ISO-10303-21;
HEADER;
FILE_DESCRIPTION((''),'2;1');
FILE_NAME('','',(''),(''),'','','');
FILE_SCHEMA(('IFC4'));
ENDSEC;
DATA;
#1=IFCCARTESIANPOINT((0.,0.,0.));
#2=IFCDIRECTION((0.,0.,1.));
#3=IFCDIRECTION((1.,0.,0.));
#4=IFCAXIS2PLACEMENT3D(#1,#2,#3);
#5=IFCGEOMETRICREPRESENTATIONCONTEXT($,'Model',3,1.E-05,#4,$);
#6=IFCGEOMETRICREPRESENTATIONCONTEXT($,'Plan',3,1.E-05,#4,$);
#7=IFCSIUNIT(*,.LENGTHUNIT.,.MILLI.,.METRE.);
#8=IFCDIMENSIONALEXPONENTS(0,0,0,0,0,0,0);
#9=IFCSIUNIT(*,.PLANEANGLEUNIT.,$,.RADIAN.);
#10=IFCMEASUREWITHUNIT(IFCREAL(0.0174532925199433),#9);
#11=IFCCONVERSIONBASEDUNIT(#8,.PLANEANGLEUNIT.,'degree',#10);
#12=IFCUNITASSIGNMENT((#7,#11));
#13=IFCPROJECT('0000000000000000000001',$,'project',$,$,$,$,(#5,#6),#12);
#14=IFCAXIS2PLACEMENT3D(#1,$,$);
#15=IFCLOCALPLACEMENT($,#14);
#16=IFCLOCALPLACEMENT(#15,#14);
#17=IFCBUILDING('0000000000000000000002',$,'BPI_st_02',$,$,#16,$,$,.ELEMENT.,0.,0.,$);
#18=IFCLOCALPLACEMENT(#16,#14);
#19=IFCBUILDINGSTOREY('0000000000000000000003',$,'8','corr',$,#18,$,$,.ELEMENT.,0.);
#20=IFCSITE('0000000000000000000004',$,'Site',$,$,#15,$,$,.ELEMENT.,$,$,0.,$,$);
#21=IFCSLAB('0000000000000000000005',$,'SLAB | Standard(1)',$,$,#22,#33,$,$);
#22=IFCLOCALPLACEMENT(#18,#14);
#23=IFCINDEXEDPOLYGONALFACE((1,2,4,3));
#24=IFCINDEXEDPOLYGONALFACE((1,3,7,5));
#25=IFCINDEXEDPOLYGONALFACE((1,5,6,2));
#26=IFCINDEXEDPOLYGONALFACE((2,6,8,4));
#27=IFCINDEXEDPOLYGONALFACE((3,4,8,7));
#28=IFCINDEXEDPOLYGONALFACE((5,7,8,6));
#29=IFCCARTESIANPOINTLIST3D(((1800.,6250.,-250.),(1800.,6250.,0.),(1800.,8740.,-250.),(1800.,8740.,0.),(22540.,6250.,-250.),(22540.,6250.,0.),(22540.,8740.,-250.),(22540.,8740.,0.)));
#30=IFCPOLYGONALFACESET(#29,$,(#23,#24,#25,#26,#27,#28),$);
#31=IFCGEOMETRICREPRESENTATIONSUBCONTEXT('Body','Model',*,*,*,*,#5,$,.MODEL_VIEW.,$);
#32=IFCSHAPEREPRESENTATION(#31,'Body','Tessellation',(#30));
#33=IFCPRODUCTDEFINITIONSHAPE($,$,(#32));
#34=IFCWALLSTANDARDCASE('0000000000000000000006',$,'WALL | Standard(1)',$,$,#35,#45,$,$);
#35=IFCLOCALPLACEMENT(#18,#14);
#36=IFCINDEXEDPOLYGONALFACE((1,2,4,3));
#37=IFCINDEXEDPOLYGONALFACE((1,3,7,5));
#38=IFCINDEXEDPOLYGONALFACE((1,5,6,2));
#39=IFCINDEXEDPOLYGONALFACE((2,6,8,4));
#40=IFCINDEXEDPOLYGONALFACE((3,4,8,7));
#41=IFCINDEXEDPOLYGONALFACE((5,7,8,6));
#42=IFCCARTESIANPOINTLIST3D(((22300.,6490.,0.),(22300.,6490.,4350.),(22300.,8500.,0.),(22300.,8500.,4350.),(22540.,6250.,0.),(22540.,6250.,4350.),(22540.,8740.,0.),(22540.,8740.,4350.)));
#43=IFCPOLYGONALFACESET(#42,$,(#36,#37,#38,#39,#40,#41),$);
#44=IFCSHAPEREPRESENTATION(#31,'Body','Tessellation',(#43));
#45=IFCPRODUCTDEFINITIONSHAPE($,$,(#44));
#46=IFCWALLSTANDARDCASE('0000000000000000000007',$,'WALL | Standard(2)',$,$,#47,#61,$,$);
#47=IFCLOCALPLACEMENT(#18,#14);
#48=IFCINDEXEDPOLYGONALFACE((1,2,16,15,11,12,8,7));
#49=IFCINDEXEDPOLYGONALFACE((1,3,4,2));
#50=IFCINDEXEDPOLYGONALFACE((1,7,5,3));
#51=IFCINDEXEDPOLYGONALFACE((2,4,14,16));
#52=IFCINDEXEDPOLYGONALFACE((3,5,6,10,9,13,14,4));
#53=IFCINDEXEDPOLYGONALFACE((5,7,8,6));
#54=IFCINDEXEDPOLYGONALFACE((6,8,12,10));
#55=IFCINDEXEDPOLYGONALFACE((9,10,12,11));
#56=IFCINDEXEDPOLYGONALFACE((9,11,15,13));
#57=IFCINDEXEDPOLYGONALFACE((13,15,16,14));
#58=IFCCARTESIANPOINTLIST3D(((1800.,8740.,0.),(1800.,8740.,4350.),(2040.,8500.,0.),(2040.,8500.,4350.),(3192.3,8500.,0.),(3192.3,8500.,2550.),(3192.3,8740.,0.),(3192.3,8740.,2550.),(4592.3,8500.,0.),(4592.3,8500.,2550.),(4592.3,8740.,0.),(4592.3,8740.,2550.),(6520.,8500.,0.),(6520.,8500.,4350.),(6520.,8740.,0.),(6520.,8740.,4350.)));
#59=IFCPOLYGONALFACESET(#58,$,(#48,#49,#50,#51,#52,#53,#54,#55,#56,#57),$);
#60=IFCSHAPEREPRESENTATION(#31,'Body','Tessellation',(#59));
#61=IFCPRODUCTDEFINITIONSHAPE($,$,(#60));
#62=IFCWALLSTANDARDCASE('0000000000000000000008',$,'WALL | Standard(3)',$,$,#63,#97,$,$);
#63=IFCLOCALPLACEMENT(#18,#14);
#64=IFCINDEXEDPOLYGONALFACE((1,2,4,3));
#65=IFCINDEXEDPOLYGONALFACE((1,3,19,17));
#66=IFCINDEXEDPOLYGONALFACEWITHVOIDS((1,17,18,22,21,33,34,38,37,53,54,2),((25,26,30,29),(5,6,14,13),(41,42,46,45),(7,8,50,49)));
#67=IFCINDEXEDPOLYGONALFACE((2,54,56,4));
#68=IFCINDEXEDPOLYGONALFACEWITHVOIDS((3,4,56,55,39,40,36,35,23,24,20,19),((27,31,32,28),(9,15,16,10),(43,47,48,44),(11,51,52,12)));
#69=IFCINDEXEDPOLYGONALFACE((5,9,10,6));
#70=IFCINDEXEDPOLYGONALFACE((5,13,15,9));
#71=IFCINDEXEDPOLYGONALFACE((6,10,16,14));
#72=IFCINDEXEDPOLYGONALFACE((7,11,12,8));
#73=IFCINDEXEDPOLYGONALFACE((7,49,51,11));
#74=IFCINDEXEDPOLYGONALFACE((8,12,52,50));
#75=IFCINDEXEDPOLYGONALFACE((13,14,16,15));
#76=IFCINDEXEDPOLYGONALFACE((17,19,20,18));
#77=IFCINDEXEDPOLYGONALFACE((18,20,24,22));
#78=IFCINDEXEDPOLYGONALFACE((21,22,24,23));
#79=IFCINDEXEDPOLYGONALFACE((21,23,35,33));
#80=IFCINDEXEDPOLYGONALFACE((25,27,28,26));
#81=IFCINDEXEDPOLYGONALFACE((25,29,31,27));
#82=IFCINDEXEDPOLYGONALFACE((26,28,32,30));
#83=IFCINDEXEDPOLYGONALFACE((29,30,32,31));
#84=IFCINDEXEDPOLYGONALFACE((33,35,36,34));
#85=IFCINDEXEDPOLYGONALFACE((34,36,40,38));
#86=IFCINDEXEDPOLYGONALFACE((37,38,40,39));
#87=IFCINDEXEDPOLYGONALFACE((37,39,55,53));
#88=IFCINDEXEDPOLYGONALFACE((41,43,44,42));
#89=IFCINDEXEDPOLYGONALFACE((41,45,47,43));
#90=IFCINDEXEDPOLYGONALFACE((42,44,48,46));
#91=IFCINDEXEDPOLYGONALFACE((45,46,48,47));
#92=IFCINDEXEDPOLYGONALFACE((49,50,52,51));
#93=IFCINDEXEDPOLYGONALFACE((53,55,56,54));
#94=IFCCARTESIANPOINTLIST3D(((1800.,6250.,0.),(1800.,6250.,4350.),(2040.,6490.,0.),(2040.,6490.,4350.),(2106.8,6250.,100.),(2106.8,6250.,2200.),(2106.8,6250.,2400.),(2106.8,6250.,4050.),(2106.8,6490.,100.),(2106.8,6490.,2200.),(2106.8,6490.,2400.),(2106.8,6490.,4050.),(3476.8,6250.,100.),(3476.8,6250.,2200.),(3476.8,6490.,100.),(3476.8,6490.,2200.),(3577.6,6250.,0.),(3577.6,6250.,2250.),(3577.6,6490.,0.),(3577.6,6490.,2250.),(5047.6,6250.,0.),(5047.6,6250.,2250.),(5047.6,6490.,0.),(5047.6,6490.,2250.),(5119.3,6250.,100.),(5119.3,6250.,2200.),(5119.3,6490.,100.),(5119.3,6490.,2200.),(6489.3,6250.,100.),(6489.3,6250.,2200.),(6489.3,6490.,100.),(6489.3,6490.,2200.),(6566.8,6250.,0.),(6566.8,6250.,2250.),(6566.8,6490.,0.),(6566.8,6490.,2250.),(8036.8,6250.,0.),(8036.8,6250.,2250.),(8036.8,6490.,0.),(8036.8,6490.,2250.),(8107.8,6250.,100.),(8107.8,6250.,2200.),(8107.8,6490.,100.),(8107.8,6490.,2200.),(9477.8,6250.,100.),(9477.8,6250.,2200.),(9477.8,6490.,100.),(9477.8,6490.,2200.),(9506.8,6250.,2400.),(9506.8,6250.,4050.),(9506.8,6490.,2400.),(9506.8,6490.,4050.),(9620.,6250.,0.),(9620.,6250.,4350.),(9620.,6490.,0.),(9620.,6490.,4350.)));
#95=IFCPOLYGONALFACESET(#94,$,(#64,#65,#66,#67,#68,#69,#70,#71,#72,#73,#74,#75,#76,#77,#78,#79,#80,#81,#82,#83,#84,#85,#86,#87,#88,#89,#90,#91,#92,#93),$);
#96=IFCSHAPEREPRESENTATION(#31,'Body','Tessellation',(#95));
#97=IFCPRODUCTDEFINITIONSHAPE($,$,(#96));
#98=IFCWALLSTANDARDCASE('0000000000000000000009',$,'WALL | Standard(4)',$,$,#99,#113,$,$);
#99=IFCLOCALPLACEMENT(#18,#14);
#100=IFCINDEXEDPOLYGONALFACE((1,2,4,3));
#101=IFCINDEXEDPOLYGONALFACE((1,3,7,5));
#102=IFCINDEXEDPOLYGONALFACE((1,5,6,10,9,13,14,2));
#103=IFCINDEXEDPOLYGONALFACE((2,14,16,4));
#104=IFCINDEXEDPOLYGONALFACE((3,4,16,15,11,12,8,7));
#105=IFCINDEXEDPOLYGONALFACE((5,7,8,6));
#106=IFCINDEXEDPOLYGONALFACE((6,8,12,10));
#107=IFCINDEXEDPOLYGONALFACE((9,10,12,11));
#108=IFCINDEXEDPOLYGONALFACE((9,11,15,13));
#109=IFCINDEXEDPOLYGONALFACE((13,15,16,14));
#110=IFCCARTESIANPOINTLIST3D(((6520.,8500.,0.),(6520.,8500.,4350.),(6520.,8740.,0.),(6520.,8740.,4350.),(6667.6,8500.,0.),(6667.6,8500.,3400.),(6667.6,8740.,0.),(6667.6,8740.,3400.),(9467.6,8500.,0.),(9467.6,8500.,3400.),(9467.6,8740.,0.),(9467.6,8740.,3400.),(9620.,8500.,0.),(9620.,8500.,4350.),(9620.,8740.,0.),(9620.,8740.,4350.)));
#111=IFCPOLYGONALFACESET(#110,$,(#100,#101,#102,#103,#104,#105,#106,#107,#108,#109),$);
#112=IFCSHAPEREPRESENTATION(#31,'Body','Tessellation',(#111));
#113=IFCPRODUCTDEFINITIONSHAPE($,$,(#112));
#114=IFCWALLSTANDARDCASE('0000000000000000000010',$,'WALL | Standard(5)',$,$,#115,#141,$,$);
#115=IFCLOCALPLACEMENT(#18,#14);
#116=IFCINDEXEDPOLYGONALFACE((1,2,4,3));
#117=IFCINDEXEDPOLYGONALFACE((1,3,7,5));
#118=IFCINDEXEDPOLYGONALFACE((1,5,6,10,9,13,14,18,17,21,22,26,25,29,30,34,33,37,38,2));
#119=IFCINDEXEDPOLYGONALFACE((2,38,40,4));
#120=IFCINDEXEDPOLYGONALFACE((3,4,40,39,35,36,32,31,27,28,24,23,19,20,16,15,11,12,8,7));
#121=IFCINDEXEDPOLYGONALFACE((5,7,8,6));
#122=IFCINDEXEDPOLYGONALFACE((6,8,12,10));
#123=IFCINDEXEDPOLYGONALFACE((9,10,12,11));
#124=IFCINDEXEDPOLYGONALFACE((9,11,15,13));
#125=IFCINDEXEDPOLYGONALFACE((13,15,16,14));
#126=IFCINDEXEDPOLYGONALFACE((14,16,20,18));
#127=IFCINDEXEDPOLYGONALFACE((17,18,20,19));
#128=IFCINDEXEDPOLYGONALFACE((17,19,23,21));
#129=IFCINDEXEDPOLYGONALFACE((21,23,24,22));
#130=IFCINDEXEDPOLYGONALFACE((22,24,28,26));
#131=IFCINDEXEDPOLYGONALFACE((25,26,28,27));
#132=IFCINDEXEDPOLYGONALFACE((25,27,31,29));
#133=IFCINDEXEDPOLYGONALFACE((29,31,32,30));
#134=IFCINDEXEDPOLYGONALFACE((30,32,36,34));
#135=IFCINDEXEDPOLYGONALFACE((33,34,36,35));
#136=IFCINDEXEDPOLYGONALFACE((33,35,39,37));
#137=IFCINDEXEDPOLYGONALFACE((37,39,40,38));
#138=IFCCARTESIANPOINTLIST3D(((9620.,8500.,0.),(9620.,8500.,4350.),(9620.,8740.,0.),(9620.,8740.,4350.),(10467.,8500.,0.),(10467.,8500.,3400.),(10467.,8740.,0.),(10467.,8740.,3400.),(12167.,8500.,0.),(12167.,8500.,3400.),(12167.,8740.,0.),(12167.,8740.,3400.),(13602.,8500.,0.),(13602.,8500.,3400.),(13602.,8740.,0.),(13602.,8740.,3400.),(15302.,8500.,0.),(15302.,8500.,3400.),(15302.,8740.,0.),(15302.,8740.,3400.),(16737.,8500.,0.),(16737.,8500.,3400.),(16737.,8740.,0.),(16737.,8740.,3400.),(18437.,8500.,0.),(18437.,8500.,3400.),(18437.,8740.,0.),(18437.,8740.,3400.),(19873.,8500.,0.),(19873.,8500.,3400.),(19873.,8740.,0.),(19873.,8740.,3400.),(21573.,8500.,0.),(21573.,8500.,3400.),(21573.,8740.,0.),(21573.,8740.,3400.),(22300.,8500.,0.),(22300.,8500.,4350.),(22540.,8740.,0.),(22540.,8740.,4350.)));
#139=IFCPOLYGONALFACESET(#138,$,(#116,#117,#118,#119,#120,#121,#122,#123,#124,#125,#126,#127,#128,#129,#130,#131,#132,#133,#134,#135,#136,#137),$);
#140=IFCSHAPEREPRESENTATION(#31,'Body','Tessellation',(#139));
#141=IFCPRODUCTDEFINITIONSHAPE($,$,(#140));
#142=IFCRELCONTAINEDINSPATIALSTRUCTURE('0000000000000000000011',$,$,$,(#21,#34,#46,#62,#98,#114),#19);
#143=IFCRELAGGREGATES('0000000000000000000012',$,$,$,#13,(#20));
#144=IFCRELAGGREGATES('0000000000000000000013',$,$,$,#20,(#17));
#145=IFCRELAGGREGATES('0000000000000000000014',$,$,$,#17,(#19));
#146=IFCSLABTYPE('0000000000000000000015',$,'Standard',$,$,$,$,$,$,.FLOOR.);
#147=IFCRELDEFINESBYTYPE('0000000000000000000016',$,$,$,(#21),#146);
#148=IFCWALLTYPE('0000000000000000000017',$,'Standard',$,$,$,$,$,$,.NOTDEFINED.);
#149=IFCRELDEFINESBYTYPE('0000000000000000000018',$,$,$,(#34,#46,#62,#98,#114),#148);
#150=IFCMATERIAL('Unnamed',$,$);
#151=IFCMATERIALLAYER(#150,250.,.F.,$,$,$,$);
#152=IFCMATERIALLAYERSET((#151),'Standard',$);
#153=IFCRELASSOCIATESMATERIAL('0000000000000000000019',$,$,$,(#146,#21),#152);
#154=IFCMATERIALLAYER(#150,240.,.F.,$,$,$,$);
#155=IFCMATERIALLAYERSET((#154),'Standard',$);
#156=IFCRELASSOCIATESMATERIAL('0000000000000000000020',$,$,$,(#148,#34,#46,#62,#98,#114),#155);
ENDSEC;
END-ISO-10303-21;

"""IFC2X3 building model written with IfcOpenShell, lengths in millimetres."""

from ifc_helpers import new_model, entity, si_unit, converted_unit, frame, frame_2d, origin, origin_with_axes, origin_2d_with_axis, place, context, subcontext, project, spatial, polyline, segment, composite_curve, rectangle, outline, extrude, material, layer, layer_set, layer_usage, type_object, element, save


model = new_model("IFC2X3")

# Units and contexts
model_context = context("Model", 3, precision=1e-05, world=origin_with_axes())
plan_context = context("Plan", 3, precision=1e-05, world=origin_with_axes())
body_context = subcontext(model_context, "Body", "Model", "MODEL_VIEW")
ifc_project = project(units=[si_unit("LENGTHUNIT", "METRE", prefix="MILLI"), converted_unit("PLANEANGLEUNIT", "degree", entity("IfcReal", 0.0174532925199433), si_unit("PLANEANGLEUNIT", "RADIAN"), dimensions=[0, 0, 0, 0, 0, 0, 0])], contexts=[model_context, plan_context])

# Site, building, storey
site_placement = place(None, origin())
site = spatial("IfcSite", under=ifc_project, at=site_placement, Name="Site", CompositionType="ELEMENT", RefElevation=0.0)
building_placement = place(site_placement, origin())
building = spatial("IfcBuilding", under=site, at=building_placement, Name="BPI_st_02", CompositionType="ELEMENT", ElevationOfRefHeight=0.0, ElevationOfTerrain=0.0)
storey_placement = place(building_placement, origin())
storey = spatial("IfcBuildingStorey", under=building, at=storey_placement, Name="8", Description="corr", CompositionType="ELEMENT", Elevation=0.0)

# Slab
ifc_material = material(Name="Unnamed")
ifc_layer_1 = layer(ifc_material, 250.0, ventilated=False)
ifc_layer_set_1 = layer_set([ifc_layer_1], Name="Standard")
ifc_layer_usage_1 = layer_usage(ifc_layer_set_1, "AXIS3", "POSITIVE", 0.0)
slab_type = type_object("IfcSlabType", Name="Standard", PredefinedType="FLOOR", material=ifc_layer_set_1)
slab_placement = place(storey_placement, frame((22540.0, 13540.0, 0.0), z_axis=(0.0, 0.0, 1.0), x_axis=(-1.0, 0.0, 0.0)))
element("IfcSlab", 1, at=slab_placement, inside=storey, type_object=slab_type, material=ifc_layer_usage_1, Name="SLAB | Standard(1)", context=body_context, shape_type="SweptSolid", body=[
    extrude(rectangle(XDim=20740.0, YDim=2490.0, at=frame_2d((10370.0, 6045.0), x_axis=(1.0, 0.0))), frame((0.0, 0.0, -250.0)), (0.0, 0.0, 1.0), 250.0),
])

# Wall
ifc_layer_2 = layer(ifc_material, 240.0, ventilated=False)
ifc_layer_set_2 = layer_set([ifc_layer_2], Name="Standard")
ifc_layer_usage_2 = layer_usage(ifc_layer_set_2, "AXIS2", "POSITIVE", -120.0)
wall_type = type_object("IfcWallType", Name="Standard", PredefinedType="NOTDEFINED", material=ifc_layer_set_2)
wall_1_placement = place(storey_placement, frame((22420.0, 8620.0, 0.0), z_axis=(0.0, 0.0, 1.0), x_axis=(0.0, -1.0, 0.0)))
element("IfcWallStandardCase", 2, at=wall_1_placement, inside=storey, type_object=wall_type, material=ifc_layer_usage_2, Name="WALL | Standard(1)", context=body_context, shape_type="SweptSolid", body=[
    extrude(outline(composite_curve([segment(polyline([(-120.0, 120.0), (120.0, -120.0)]), True, "CONTINUOUS"), segment(polyline([(120.0, -120.0), (2130.0, -120.0)]), True, "CONTINUOUS"), segment(polyline([(2130.0, -120.0), (2370.0, 120.0)]), True, "CONTINUOUS"), segment(polyline([(2370.0, 120.0), (-120.0, 120.0)]), True, "CONTINUOUS")], self_intersect=False)), origin(), (0.0, 0.0, 1.0), 4350.0),
])

# Wall, opening
ifc_layer_usage_3 = layer_usage(ifc_layer_set_2, "AXIS2", "POSITIVE", -120.0)
wall_2_placement = place(storey_placement, frame((1920.0, 8620.0, 0.0)))
wall_2 = element("IfcWallStandardCase", 3, at=wall_2_placement, inside=storey, type_object=wall_type, material=ifc_layer_usage_3, Name="WALL | Standard(2)", context=body_context, shape_type="SweptSolid", body=[
    extrude(outline(composite_curve([segment(polyline([(-120.0, 120.0), (120.0, -120.0)]), True, "CONTINUOUS"), segment(polyline([(120.0, -120.0), (4600.1, -120.0)]), True, "CONTINUOUS"), segment(polyline([(4600.1, -120.0), (4600.1, 120.0)]), True, "CONTINUOUS"), segment(polyline([(4600.1, 120.0), (-120.0, 120.0)]), True, "CONTINUOUS")], self_intersect=False)), origin(), (0.0, 0.0, 1.0), 4350.0),
])
opening_1_placement = place(wall_2_placement, frame((1272.4, 0.0, 0.0)))
element("IfcOpeningElement", 4, at=opening_1_placement, cuts=wall_2, context=body_context, shape_type="SweptSolid", body=[
    extrude(rectangle(XDim=1400.0, YDim=2550.0, at=origin_2d_with_axis()), frame((700.0, 120.0, 1275.0), z_axis=(0.0, -1.0, 0.0), x_axis=(1.0, 0.0, 0.0)), (0.0, 0.0, 1.0), 240.0),
])

# Wall, openings
ifc_layer_usage_4 = layer_usage(ifc_layer_set_2, "AXIS2", "POSITIVE", -120.0)
wall_3_placement = place(storey_placement, frame((1920.0, 6370.0, 0.0)))
wall_3 = element("IfcWallStandardCase", 5, at=wall_3_placement, inside=storey, type_object=wall_type, material=ifc_layer_usage_4, Name="WALL | Standard(3)", context=body_context, shape_type="SweptSolid", body=[
    extrude(outline(composite_curve([segment(polyline([(120.0, 120.0), (-120.0, -120.0)]), True, "CONTINUOUS"), segment(polyline([(-120.0, -120.0), (7700.1, -120.0)]), True, "CONTINUOUS"), segment(polyline([(7700.1, -120.0), (7700.1, 120.0)]), True, "CONTINUOUS"), segment(polyline([(7700.1, 120.0), (120.0, 120.0)]), True, "CONTINUOUS")], self_intersect=False)), origin(), (0.0, 0.0, 1.0), 4350.0),
])
opening_2_placement = place(wall_3_placement, frame((186.8, 0.0, 2400.0)))
element("IfcOpeningElement", 6, at=opening_2_placement, cuts=wall_3, context=body_context, shape_type="SweptSolid", body=[
    extrude(rectangle(XDim=7400.0, YDim=1650.0, at=origin_2d_with_axis()), frame((3700.0, 120.0, 825.0), z_axis=(0.0, -1.0, 0.0), x_axis=(1.0, 0.0, 0.0)), (0.0, 0.0, 1.0), 240.0),
])
opening_3_placement = place(wall_3_placement, frame((186.8, 0.0, 100.0)))
element("IfcOpeningElement", 7, at=opening_3_placement, cuts=wall_3, context=body_context, shape_type="SweptSolid", body=[
    extrude(rectangle(XDim=1370.0, YDim=2100.0, at=origin_2d_with_axis()), frame((685.0, 120.0, 1050.0), z_axis=(0.0, -1.0, 0.0), x_axis=(1.0, 0.0, 0.0)), (0.0, 0.0, 1.0), 240.0),
])
opening_4_placement = place(wall_3_placement, frame((3199.3, 0.0, 100.0)))
element("IfcOpeningElement", 8, at=opening_4_placement, cuts=wall_3, context=body_context, shape_type="SweptSolid", body=[
    extrude(rectangle(XDim=1370.0, YDim=2100.0, at=origin_2d_with_axis()), frame((685.0, 120.0, 1050.0), z_axis=(0.0, -1.0, 0.0), x_axis=(1.0, 0.0, 0.0)), (0.0, 0.0, 1.0), 240.0),
])
opening_5_placement = place(wall_3_placement, frame((6187.8, 0.0, 100.0)))
element("IfcOpeningElement", 9, at=opening_5_placement, cuts=wall_3, context=body_context, shape_type="SweptSolid", body=[
    extrude(rectangle(XDim=1370.0, YDim=2100.0, at=origin_2d_with_axis()), frame((685.0, 120.0, 1050.0), z_axis=(0.0, -1.0, 0.0), x_axis=(1.0, 0.0, 0.0)), (0.0, 0.0, 1.0), 240.0),
])
opening_6_placement = place(wall_3_placement, frame((1657.7, 0.0, 0.0)))
element("IfcOpeningElement", 10, at=opening_6_placement, cuts=wall_3, context=body_context, shape_type="SweptSolid", body=[
    extrude(rectangle(XDim=2250.0, YDim=1470.0, at=frame_2d((0.0, 0.0), x_axis=(0.0, 1.0))), frame((735.0, 120.0, 1125.0), z_axis=(0.0, -1.0, 0.0), x_axis=(1.0, 0.0, 0.0)), (0.0, 0.0, 1.0), 240.0),
])
opening_7_placement = place(wall_3_placement, frame((4646.9, 0.0, 0.0)))
element("IfcOpeningElement", 11, at=opening_7_placement, cuts=wall_3, context=body_context, shape_type="SweptSolid", body=[
    extrude(rectangle(XDim=2250.0, YDim=1470.0, at=frame_2d((0.0, 0.0), x_axis=(0.0, 1.0))), frame((735.0, 120.0, 1125.0), z_axis=(0.0, -1.0, 0.0), x_axis=(1.0, 0.0, 0.0)), (0.0, 0.0, 1.0), 240.0),
])

# Wall, opening
ifc_layer_usage_5 = layer_usage(ifc_layer_set_2, "AXIS2", "POSITIVE", -120.0)
wall_4_placement = place(storey_placement, frame((6520.0, 8620.0, 0.0)))
wall_4 = element("IfcWallStandardCase", 12, at=wall_4_placement, inside=storey, type_object=wall_type, material=ifc_layer_usage_5, Name="WALL | Standard(4)", context=body_context, shape_type="SweptSolid", body=[
    extrude(rectangle(XDim=240.0, YDim=3100.0, at=frame_2d((1550.0, 0.0), x_axis=(0.0, -1.0))), origin(), (0.0, 0.0, 1.0), 4350.0),
])
opening_8_placement = place(wall_4_placement, frame((147.5, 0.0, 0.0)))
element("IfcOpeningElement", 13, at=opening_8_placement, cuts=wall_4, context=body_context, shape_type="SweptSolid", body=[
    extrude(rectangle(XDim=2800.0, YDim=3400.0, at=origin_2d_with_axis()), frame((1400.0, 120.0, 1700.0), z_axis=(0.0, -1.0, 0.0), x_axis=(1.0, 0.0, 0.0)), (0.0, 0.0, 1.0), 240.0),
])

# Wall, openings
ifc_layer_usage_6 = layer_usage(ifc_layer_set_2, "AXIS2", "POSITIVE", -120.0)
wall_5_placement = place(storey_placement, frame((9620.0, 8620.0, 0.0)))
wall_5 = element("IfcWallStandardCase", 14, at=wall_5_placement, inside=storey, type_object=wall_type, material=ifc_layer_usage_6, Name="WALL | Standard(5)", context=body_context, shape_type="SweptSolid", body=[
    extrude(outline(composite_curve([segment(polyline([(0.0, 120.0), (0.0, -120.0)]), True, "CONTINUOUS"), segment(polyline([(0.0, -120.0), (12680.0, -120.0)]), True, "CONTINUOUS"), segment(polyline([(12680.0, -120.0), (12920.0, 120.0)]), True, "CONTINUOUS"), segment(polyline([(12920.0, 120.0), (0.0, 120.0)]), True, "CONTINUOUS")], self_intersect=False)), origin(), (0.0, 0.0, 1.0), 4350.0),
])
opening_9_placement = place(wall_5_placement, frame((847.0, 0.0, 0.0)))
element("IfcOpeningElement", 15, at=opening_9_placement, cuts=wall_5, context=body_context, shape_type="SweptSolid", body=[
    extrude(rectangle(XDim=1700.0, YDim=3400.0, at=origin_2d_with_axis()), frame((850.0, 120.0, 1700.0), z_axis=(0.0, -1.0, 0.0), x_axis=(1.0, 0.0, 0.0)), (0.0, 0.0, 1.0), 240.0),
])
opening_10_placement = place(wall_5_placement, frame((3982.0, 0.0, 0.0)))
element("IfcOpeningElement", 16, at=opening_10_placement, cuts=wall_5, context=body_context, shape_type="SweptSolid", body=[
    extrude(rectangle(XDim=1700.0, YDim=3400.0, at=origin_2d_with_axis()), frame((850.0, 120.0, 1700.0), z_axis=(0.0, -1.0, 0.0), x_axis=(1.0, 0.0, 0.0)), (0.0, 0.0, 1.0), 240.0),
])
opening_11_placement = place(wall_5_placement, frame((7117.0, 0.0, 0.0)))
element("IfcOpeningElement", 17, at=opening_11_placement, cuts=wall_5, context=body_context, shape_type="SweptSolid", body=[
    extrude(rectangle(XDim=1700.0, YDim=3400.0, at=origin_2d_with_axis()), frame((850.0, 120.0, 1700.0), z_axis=(0.0, -1.0, 0.0), x_axis=(1.0, 0.0, 0.0)), (0.0, 0.0, 1.0), 240.0),
])
opening_12_placement = place(wall_5_placement, frame((10253.0, 0.0, 0.0)))
element("IfcOpeningElement", 18, at=opening_12_placement, cuts=wall_5, context=body_context, shape_type="SweptSolid", body=[
    extrude(rectangle(XDim=1700.0, YDim=3400.0, at=origin_2d_with_axis()), frame((850.0, 120.0, 1700.0), z_axis=(0.0, -1.0, 0.0), x_axis=(1.0, 0.0, 0.0)), (0.0, 0.0, 1.0), 240.0),
])

save(model, "model.ifc")
